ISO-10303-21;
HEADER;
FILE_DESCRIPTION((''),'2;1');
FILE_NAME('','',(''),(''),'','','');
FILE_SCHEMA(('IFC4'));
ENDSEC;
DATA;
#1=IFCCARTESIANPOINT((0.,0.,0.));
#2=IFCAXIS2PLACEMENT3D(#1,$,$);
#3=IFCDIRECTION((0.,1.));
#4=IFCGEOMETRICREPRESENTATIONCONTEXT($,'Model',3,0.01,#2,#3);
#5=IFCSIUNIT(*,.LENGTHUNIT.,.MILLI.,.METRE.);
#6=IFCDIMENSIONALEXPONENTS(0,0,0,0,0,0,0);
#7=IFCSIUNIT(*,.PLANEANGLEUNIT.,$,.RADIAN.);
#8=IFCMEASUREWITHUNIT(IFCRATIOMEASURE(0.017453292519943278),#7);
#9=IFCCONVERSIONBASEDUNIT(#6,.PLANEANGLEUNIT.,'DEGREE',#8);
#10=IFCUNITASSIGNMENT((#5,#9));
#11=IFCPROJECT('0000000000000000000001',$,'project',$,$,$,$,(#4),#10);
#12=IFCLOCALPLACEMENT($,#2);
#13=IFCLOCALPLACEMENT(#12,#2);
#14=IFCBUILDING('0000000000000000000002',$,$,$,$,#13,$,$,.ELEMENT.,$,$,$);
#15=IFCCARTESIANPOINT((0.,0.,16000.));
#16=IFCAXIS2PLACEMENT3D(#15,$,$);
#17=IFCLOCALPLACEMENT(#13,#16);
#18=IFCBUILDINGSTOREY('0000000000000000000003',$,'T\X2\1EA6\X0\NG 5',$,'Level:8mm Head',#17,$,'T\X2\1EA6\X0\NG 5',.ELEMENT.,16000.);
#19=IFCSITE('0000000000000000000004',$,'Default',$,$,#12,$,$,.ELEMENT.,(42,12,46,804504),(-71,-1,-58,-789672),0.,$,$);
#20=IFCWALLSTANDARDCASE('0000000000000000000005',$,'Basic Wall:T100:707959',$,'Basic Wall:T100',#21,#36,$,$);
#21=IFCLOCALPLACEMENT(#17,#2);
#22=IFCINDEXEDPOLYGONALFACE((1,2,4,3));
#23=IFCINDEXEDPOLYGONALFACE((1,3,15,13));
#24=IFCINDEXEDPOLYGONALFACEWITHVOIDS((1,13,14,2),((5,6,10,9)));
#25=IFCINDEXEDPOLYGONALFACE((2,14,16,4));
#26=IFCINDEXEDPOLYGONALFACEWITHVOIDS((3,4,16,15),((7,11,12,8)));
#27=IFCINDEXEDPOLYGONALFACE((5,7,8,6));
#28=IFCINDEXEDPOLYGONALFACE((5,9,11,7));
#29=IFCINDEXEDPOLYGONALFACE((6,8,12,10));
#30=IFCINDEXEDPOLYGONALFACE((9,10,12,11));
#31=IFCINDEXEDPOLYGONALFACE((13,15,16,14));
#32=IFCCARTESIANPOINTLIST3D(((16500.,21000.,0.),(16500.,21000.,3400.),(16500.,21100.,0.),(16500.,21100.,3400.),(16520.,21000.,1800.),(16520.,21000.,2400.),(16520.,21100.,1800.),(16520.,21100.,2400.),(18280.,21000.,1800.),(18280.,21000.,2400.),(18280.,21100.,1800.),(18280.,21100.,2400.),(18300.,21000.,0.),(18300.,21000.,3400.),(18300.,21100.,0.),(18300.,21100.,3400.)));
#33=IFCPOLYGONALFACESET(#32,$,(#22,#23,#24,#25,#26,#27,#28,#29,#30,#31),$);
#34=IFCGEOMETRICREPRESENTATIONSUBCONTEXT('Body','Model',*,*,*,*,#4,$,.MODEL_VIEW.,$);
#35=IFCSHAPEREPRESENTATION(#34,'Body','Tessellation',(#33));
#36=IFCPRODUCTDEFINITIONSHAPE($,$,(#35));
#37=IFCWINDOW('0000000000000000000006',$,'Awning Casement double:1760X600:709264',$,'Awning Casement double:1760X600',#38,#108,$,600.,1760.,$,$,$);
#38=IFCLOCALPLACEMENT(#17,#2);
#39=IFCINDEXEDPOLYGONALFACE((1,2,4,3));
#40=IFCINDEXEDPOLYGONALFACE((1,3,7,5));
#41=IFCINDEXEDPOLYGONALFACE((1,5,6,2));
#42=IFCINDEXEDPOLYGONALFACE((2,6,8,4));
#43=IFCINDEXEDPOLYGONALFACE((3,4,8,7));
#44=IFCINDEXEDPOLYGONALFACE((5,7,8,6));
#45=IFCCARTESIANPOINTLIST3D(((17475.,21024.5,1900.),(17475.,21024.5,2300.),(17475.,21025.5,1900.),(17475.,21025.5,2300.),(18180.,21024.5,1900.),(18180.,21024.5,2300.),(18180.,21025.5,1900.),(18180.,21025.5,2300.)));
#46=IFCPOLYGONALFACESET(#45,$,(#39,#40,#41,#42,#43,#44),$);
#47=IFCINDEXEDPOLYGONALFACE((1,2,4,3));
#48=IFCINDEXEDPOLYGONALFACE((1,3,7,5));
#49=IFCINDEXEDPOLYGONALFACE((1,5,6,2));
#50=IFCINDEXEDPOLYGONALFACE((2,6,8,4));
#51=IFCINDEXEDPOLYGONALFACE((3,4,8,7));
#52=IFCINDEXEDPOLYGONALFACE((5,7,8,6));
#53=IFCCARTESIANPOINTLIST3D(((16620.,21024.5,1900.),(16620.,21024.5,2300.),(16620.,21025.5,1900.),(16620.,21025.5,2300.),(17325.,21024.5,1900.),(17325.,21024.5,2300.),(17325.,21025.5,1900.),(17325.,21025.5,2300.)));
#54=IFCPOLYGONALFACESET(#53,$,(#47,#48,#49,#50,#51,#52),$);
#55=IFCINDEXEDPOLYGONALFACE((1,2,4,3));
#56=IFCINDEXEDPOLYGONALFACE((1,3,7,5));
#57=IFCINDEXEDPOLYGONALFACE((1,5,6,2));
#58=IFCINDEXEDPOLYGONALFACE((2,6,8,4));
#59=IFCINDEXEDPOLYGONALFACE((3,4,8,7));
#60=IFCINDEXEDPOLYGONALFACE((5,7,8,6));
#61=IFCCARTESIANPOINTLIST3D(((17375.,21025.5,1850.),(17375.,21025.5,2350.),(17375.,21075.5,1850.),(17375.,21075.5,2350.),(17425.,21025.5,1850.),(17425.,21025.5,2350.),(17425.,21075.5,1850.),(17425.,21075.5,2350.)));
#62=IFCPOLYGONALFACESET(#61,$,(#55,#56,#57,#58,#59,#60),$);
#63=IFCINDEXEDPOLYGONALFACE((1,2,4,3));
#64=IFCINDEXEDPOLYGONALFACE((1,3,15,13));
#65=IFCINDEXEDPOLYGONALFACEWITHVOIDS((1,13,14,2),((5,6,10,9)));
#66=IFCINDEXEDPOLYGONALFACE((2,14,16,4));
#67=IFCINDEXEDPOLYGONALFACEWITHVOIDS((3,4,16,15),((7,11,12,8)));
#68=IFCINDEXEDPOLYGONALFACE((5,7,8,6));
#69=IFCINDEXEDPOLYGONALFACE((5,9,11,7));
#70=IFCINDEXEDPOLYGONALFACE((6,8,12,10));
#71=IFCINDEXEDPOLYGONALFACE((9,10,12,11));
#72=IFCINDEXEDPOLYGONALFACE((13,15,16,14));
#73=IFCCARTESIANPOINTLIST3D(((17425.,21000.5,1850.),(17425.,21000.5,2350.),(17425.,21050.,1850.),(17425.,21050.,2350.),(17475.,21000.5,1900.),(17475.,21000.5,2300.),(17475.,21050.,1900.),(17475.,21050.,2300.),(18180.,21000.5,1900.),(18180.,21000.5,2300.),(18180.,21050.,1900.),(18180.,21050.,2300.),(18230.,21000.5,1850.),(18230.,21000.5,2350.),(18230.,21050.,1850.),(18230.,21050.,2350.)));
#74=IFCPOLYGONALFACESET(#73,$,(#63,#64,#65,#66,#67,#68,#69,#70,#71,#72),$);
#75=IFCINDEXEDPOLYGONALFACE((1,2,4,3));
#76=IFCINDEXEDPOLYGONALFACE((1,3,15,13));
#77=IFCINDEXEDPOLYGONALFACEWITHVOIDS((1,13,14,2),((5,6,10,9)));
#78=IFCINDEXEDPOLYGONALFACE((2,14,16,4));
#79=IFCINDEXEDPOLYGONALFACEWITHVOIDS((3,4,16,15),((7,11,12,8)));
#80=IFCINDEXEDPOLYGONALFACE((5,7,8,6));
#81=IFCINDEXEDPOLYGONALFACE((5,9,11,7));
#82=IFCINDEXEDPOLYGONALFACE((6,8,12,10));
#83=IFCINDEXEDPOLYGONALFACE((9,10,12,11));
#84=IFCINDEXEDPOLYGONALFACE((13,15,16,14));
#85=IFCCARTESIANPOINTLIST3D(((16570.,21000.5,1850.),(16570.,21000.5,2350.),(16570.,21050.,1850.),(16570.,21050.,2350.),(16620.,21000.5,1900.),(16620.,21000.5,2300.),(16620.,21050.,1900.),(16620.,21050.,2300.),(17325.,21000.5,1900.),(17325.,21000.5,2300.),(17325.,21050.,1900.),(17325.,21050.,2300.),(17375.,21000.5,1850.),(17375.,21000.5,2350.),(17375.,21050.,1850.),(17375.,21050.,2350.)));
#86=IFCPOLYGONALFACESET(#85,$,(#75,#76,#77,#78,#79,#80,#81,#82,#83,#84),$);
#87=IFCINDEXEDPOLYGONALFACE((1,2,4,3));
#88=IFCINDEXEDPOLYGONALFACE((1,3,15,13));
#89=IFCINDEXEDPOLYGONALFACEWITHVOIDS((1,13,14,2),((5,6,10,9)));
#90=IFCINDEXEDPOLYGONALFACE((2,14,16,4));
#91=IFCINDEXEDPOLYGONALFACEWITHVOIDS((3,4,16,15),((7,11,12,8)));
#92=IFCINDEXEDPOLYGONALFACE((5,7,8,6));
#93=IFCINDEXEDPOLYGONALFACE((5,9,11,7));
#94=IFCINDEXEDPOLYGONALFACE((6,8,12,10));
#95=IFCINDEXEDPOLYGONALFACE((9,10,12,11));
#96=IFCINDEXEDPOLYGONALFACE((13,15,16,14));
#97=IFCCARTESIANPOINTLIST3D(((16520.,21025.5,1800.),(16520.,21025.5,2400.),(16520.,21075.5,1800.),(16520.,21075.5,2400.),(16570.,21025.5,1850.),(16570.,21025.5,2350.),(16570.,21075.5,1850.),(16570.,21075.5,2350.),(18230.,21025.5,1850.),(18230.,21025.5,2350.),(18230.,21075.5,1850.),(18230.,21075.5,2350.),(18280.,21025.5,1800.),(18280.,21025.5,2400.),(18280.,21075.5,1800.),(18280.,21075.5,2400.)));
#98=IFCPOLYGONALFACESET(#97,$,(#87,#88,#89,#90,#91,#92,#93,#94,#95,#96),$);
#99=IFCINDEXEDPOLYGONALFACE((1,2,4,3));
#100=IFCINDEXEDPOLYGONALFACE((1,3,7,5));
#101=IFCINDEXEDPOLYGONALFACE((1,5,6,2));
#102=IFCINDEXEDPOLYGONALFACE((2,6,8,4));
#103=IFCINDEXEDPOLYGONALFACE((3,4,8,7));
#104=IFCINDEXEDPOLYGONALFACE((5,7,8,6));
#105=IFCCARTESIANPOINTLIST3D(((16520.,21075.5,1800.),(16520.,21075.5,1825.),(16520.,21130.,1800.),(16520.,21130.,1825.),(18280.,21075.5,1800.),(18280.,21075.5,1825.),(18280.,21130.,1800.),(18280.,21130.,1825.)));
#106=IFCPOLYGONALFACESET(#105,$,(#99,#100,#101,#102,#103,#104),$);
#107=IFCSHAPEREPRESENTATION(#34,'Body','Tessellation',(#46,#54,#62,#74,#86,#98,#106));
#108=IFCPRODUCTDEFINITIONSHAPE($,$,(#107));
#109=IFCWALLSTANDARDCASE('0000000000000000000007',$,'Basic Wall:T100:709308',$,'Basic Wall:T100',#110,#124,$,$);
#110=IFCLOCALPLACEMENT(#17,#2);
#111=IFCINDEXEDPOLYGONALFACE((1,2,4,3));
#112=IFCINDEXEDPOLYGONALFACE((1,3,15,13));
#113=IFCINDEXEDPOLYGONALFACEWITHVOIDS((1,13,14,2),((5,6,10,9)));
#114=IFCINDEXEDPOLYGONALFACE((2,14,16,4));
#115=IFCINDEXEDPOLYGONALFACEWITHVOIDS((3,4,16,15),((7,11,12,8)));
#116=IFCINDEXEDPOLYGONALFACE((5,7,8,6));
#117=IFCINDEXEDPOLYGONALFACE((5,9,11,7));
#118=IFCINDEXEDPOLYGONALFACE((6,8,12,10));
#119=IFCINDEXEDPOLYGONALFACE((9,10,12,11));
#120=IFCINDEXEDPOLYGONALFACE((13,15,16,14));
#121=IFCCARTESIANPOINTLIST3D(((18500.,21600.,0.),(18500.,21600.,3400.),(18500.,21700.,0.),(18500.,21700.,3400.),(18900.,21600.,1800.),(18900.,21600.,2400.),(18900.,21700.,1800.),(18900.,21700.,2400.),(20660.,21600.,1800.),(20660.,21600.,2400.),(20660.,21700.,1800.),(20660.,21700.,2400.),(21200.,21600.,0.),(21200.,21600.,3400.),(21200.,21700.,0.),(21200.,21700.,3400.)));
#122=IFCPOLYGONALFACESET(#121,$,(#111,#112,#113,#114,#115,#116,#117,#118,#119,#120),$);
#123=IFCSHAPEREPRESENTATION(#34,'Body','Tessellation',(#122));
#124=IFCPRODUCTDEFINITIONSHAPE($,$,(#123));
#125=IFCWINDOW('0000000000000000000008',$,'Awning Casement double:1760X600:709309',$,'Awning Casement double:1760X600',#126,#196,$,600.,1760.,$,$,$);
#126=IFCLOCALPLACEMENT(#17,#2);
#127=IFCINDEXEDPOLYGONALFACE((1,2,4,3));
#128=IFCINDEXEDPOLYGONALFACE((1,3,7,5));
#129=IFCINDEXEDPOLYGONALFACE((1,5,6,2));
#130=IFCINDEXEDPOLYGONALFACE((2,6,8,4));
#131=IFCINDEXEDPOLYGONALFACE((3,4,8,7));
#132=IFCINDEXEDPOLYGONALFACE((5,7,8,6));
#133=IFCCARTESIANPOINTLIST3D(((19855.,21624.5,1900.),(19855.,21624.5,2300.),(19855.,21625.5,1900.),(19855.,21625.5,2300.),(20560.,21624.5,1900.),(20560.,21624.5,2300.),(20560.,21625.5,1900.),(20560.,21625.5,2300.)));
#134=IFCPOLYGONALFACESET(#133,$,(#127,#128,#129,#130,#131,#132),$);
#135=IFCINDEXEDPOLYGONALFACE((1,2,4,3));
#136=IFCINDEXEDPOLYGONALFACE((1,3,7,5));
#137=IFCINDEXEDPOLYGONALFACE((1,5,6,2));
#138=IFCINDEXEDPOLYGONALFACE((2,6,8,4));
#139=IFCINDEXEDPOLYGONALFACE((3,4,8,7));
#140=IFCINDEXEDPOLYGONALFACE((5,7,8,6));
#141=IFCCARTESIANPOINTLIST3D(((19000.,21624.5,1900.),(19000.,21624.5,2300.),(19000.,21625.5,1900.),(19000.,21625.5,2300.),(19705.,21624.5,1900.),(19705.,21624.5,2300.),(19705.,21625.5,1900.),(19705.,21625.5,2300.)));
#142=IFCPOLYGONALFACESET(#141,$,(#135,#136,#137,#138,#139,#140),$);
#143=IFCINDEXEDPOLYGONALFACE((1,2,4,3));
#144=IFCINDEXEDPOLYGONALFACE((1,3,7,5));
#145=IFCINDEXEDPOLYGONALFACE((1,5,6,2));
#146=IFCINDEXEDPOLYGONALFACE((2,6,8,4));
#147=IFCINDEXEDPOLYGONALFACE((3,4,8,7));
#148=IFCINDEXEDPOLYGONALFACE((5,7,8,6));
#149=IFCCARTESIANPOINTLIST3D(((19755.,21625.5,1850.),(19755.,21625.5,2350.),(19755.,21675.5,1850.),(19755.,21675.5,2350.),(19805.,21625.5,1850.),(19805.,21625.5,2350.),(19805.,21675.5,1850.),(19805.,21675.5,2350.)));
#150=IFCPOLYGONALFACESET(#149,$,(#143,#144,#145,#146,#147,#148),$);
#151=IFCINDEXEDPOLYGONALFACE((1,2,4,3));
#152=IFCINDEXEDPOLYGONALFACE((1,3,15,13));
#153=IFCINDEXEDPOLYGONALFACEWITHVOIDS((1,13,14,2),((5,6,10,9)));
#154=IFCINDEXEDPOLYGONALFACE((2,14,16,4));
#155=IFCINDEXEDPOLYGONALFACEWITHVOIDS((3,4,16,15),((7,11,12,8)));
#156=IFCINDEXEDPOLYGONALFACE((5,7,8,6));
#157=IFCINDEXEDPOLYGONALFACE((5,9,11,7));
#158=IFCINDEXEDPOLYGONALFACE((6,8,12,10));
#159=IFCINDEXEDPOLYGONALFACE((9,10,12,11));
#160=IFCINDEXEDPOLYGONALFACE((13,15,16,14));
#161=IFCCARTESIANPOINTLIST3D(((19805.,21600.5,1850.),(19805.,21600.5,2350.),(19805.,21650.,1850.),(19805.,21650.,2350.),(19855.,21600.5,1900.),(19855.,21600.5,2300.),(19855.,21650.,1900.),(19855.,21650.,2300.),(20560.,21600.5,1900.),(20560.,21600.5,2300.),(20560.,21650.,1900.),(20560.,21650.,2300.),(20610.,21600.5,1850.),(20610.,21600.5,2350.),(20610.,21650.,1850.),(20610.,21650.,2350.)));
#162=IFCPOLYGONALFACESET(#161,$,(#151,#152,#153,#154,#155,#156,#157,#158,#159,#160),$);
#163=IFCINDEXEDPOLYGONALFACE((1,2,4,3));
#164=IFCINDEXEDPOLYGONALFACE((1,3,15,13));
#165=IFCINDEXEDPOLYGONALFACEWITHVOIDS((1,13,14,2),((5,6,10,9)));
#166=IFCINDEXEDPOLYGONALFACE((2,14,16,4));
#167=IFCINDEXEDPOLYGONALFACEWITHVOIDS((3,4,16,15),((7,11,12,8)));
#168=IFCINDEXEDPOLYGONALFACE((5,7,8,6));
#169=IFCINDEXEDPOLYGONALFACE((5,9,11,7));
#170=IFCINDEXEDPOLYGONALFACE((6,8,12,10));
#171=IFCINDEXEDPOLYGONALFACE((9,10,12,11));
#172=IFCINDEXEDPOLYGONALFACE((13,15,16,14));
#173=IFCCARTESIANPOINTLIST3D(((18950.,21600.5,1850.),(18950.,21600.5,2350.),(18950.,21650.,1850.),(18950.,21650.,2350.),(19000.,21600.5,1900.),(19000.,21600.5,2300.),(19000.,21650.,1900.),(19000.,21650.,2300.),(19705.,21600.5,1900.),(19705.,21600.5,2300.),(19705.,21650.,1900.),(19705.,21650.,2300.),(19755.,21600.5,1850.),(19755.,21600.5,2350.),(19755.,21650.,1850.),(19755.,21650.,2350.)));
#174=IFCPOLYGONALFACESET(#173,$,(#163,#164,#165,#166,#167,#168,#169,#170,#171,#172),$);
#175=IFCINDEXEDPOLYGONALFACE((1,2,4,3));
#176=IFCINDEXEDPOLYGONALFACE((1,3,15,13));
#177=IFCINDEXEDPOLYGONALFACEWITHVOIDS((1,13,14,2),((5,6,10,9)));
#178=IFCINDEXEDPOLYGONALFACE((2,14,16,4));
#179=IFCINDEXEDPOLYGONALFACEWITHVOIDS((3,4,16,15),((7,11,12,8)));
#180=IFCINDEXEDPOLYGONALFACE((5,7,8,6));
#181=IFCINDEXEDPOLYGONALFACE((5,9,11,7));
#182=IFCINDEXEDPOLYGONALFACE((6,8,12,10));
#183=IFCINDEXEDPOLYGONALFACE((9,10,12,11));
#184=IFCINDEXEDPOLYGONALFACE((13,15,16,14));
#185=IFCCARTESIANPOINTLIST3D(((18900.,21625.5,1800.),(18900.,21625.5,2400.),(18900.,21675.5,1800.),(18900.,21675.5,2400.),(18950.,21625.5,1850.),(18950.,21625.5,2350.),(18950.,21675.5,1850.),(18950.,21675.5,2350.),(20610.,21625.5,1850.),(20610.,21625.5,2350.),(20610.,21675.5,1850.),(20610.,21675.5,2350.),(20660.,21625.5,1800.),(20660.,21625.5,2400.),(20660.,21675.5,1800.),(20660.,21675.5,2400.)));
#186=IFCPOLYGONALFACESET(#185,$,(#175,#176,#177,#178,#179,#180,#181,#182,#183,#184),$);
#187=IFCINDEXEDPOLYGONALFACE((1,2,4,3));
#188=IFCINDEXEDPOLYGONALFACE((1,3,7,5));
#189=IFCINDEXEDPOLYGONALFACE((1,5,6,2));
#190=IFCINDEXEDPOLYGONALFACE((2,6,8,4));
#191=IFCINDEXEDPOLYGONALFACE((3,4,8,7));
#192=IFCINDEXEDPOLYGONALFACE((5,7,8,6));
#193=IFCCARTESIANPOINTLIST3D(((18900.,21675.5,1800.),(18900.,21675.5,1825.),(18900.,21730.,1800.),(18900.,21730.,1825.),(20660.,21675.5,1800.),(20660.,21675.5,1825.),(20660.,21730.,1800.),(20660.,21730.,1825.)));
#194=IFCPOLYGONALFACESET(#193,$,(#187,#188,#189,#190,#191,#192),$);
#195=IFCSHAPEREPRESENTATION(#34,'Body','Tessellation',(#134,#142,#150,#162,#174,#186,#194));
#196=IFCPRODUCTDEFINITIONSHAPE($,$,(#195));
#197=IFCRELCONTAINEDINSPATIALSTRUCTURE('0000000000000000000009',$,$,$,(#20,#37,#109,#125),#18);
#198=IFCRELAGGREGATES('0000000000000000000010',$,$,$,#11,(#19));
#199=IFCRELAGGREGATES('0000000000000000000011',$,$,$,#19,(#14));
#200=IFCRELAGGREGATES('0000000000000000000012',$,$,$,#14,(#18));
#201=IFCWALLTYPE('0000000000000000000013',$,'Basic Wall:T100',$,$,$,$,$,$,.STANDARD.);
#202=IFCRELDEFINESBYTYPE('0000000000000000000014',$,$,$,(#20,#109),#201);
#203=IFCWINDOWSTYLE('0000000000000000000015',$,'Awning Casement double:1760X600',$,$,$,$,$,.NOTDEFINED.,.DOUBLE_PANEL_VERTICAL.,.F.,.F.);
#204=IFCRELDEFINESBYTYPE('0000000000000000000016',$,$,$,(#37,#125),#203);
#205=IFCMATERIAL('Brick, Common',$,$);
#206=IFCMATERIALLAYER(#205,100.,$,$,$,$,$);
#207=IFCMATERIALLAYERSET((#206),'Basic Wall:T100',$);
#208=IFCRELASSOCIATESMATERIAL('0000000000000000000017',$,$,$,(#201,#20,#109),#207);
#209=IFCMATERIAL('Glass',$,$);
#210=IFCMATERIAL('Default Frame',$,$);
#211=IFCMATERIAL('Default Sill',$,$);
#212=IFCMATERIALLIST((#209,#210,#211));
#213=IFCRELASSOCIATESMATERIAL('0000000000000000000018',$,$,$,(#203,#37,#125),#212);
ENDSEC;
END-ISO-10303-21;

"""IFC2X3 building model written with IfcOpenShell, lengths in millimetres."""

from ifc_helpers import new_model, entity, si_unit, converted_unit, direction, frame, frame_2d, origin, origin_2d_with_axis, place, context, subcontext, project, spatial, polyline, rectangle, outline, extrude, source, transform, mapped, material, material_list, layer, layer_set, layer_usage, type_object, type_shapes, element, fill, save


model = new_model("IFC2X3")

# Units and contexts
model_context = context("Model", 3, precision=0.01, world=origin(), true_north=direction((0.0, 1.0)))
body_context = subcontext(model_context, "Body", "Model", "MODEL_VIEW")
ifc_project = project(units=[si_unit("LENGTHUNIT", "METRE", prefix="MILLI"), converted_unit("PLANEANGLEUNIT", "DEGREE", entity("IfcRatioMeasure", 0.017453292519943278), si_unit("PLANEANGLEUNIT", "RADIAN"), dimensions=[0, 0, 0, 0, 0, 0, 0])], contexts=[model_context])

# Site, building, storey
site_placement = place(None, origin())
site = spatial("IfcSite", under=ifc_project, at=site_placement, Name="Default", CompositionType="ELEMENT", RefLatitude=(42, 12, 46, 804504), RefLongitude=(-71, -1, -58, -789672), RefElevation=0.0)
building_placement = place(site_placement, origin())
building = spatial("IfcBuilding", under=site, at=building_placement, CompositionType="ELEMENT")
storey_placement = place(building_placement, frame((0.0, 0.0, 16000.0)))
storey = spatial("IfcBuildingStorey", under=building, at=storey_placement, Name="TẦNG 5", ObjectType="Level:8mm Head", LongName="TẦNG 5", CompositionType="ELEMENT", Elevation=16000.0)

# Shared definitions
ifc_material_1 = material(Name="Glass")

# Shared definitions
ifc_material_2 = material(Name="Brick, Common")
ifc_layer_1 = layer(ifc_material_2, 100.0)
ifc_layer_set_1 = layer_set([ifc_layer_1], Name="Basic Wall:T100")
wall_type_1 = type_object("IfcWallType", Name="Basic Wall:T100", PredefinedType="STANDARD", material=ifc_layer_set_1)

# Walls, openings, windows
ifc_layer_usage_1 = layer_usage(ifc_layer_set_1, "AXIS2", "NEGATIVE", 50.0)
wall_1_placement = place(storey_placement, frame((16500.0, 21050.0, 0.0)))
wall_1 = element("IfcWallStandardCase", 1, at=wall_1_placement, inside=storey, type_object=wall_type_1, material=ifc_layer_usage_1, Name="Basic Wall:T100:707959", ObjectType="Basic Wall:T100", context=body_context, shape_type="SweptSolid", body=[
    extrude(rectangle(XDim=1800.0, YDim=100.0, at=frame_2d((900.0, 0.0), x_axis=(-1.0, 0.0))), origin(), (0.0, 0.0, 1.0), 3400.0),
])
opening_1_placement = place(wall_1_placement, frame((20.0, -50.0, 1800.0)))
opening_1 = element("IfcOpeningElement", 2, at=opening_1_placement, cuts=wall_1, ObjectType="Opening", context=body_context, shape_type="SweptSolid", body=[
    extrude(rectangle(XDim=600.0, YDim=1760.0, at=frame_2d((300.0, 880.0), x_axis=(1.0, 0.0))), frame((0.0, 0.0, 0.0), z_axis=(0.0, 1.0, 0.0), x_axis=(0.0, 0.0, 1.0)), (0.0, 0.0, 1.0), 100.0),
])
ifc_material_3 = material(Name="Default Frame")
ifc_material_4 = material(Name="Default Sill")
ifc_material_list = material_list([ifc_material_1, ifc_material_3, ifc_material_4])
window_style = type_object("IfcWindowStyle", Name="Awning Casement double:1760X600", ConstructionType="NOTDEFINED", OperationType="DOUBLE_PANEL_VERTICAL", ParameterTakesPrecedence=False, Sizeable=False, material=ifc_material_list)
shared_shape_1 = source(origin(), body_context, "Body", "SweptSolid", [
    extrude(rectangle(XDim=1.0, YDim=705.0, at=origin_2d_with_axis()), frame((1307.5, 25.0, 100.0), z_axis=(0.0, 0.0, 1.0), x_axis=(0.0, 1.0, 0.0)), (0.0, 0.0, 1.0), 400.0),
    extrude(rectangle(XDim=1.0, YDim=705.0, at=origin_2d_with_axis()), frame((452.5, 25.0, 100.0), z_axis=(0.0, 0.0, 1.0), x_axis=(0.0, 1.0, 0.0)), (0.0, 0.0, 1.0), 400.0),
    extrude(rectangle(XDim=50.0, YDim=50.0, at=origin_2d_with_axis()), frame((880.0, 50.5, 50.0), z_axis=(0.0, 0.0, 1.0), x_axis=(0.0, 1.0, 0.0)), (0.0, 0.0, 1.0), 500.0),
    extrude(outline(polyline([(-250.0, -402.5), (250.0, -402.5), (250.0, 402.5), (-250.0, 402.5), (-250.0, -402.5)]), holes=[polyline([(-200.0, -352.5), (-200.0, 352.5), (200.0, 352.5), (200.0, -352.5), (-200.0, -352.5)])]), frame((1307.5, 0.5, 300.0), z_axis=(0.0, 1.0, 0.0), x_axis=(0.0, 0.0, -1.0)), (0.0, 0.0, 1.0), 49.5),
    extrude(outline(polyline([(-250.0, -402.5), (250.0, -402.5), (250.0, 402.5), (-250.0, 402.5), (-250.0, -402.5)]), holes=[polyline([(-200.0, -352.5), (-200.0, 352.5), (200.0, 352.5), (200.0, -352.5), (-200.0, -352.5)])]), frame((452.5, 0.5, 300.0), z_axis=(0.0, 1.0, 0.0), x_axis=(0.0, 0.0, -1.0)), (0.0, 0.0, 1.0), 49.5),
    extrude(outline(polyline([(-300.0, -880.0), (300.0, -880.0), (300.0, 880.0), (-300.0, 880.0), (-300.0, -880.0)]), holes=[polyline([(-250.0, -830.0), (-250.0, 830.0), (250.0, 830.0), (250.0, -830.0), (-250.0, -830.0)])]), frame((880.0, 25.5, 300.0), z_axis=(0.0, 1.0, 0.0), x_axis=(0.0, 0.0, -1.0)), (0.0, 0.0, 1.0), 50.0),
    extrude(rectangle(XDim=54.5, YDim=1760.0, at=origin_2d_with_axis()), frame((880.0, 102.8, 0.0), z_axis=(0.0, 0.0, 1.0), x_axis=(0.0, 1.0, 0.0)), (0.0, 0.0, 1.0), 25.0),
])
type_shapes(window_style, [shared_shape_1])
window_1_placement = place(opening_1_placement, origin())
window_1 = element("IfcWindow", 3, at=window_1_placement, inside=storey, type_object=window_style, material=ifc_material_list, Name="Awning Casement double:1760X600:709264", ObjectType="Awning Casement double:1760X600", OverallHeight=600.0, OverallWidth=1760.0, context=body_context, shape_type="MappedRepresentation", body=[
    mapped(shared_shape_1, transform((0.0, 0.0, 0.0), scale=1.0)),
])
fill(opening_1, window_1)
wall_2_placement = place(storey_placement, frame((18500.0, 21650.0, 0.0)))
wall_2 = element("IfcWallStandardCase", 4, at=wall_2_placement, inside=storey, type_object=wall_type_1, material=ifc_layer_usage_1, Name="Basic Wall:T100:709308", ObjectType="Basic Wall:T100", context=body_context, shape_type="SweptSolid", body=[
    extrude(rectangle(XDim=2700.0, YDim=100.0, at=frame_2d((1350.0, 0.0), x_axis=(-1.0, 0.0))), origin(), (0.0, 0.0, 1.0), 3400.0),
])
opening_2_placement = place(wall_2_placement, frame((400.0, -50.0, 1800.0)))
opening_2 = element("IfcOpeningElement", 5, at=opening_2_placement, cuts=wall_2, ObjectType="Opening", context=body_context, shape_type="SweptSolid", body=[
    extrude(rectangle(XDim=600.0, YDim=1760.0, at=frame_2d((300.0, 880.0), x_axis=(1.0, 0.0))), frame((0.0, 0.0, 0.0), z_axis=(0.0, 1.0, 0.0), x_axis=(0.0, 0.0, 1.0)), (0.0, 0.0, 1.0), 100.0),
])
window_2_placement = place(opening_2_placement, origin())
window_2 = element("IfcWindow", 6, at=window_2_placement, inside=storey, type_object=window_style, material=ifc_material_list, Name="Awning Casement double:1760X600:709309", ObjectType="Awning Casement double:1760X600", OverallHeight=600.0, OverallWidth=1760.0, context=body_context, shape_type="MappedRepresentation", body=[
    mapped(shared_shape_1, transform((0.0, 0.0, 0.0), scale=1.0)),
])
fill(opening_2, window_2)

save(model, "model.ifc")
